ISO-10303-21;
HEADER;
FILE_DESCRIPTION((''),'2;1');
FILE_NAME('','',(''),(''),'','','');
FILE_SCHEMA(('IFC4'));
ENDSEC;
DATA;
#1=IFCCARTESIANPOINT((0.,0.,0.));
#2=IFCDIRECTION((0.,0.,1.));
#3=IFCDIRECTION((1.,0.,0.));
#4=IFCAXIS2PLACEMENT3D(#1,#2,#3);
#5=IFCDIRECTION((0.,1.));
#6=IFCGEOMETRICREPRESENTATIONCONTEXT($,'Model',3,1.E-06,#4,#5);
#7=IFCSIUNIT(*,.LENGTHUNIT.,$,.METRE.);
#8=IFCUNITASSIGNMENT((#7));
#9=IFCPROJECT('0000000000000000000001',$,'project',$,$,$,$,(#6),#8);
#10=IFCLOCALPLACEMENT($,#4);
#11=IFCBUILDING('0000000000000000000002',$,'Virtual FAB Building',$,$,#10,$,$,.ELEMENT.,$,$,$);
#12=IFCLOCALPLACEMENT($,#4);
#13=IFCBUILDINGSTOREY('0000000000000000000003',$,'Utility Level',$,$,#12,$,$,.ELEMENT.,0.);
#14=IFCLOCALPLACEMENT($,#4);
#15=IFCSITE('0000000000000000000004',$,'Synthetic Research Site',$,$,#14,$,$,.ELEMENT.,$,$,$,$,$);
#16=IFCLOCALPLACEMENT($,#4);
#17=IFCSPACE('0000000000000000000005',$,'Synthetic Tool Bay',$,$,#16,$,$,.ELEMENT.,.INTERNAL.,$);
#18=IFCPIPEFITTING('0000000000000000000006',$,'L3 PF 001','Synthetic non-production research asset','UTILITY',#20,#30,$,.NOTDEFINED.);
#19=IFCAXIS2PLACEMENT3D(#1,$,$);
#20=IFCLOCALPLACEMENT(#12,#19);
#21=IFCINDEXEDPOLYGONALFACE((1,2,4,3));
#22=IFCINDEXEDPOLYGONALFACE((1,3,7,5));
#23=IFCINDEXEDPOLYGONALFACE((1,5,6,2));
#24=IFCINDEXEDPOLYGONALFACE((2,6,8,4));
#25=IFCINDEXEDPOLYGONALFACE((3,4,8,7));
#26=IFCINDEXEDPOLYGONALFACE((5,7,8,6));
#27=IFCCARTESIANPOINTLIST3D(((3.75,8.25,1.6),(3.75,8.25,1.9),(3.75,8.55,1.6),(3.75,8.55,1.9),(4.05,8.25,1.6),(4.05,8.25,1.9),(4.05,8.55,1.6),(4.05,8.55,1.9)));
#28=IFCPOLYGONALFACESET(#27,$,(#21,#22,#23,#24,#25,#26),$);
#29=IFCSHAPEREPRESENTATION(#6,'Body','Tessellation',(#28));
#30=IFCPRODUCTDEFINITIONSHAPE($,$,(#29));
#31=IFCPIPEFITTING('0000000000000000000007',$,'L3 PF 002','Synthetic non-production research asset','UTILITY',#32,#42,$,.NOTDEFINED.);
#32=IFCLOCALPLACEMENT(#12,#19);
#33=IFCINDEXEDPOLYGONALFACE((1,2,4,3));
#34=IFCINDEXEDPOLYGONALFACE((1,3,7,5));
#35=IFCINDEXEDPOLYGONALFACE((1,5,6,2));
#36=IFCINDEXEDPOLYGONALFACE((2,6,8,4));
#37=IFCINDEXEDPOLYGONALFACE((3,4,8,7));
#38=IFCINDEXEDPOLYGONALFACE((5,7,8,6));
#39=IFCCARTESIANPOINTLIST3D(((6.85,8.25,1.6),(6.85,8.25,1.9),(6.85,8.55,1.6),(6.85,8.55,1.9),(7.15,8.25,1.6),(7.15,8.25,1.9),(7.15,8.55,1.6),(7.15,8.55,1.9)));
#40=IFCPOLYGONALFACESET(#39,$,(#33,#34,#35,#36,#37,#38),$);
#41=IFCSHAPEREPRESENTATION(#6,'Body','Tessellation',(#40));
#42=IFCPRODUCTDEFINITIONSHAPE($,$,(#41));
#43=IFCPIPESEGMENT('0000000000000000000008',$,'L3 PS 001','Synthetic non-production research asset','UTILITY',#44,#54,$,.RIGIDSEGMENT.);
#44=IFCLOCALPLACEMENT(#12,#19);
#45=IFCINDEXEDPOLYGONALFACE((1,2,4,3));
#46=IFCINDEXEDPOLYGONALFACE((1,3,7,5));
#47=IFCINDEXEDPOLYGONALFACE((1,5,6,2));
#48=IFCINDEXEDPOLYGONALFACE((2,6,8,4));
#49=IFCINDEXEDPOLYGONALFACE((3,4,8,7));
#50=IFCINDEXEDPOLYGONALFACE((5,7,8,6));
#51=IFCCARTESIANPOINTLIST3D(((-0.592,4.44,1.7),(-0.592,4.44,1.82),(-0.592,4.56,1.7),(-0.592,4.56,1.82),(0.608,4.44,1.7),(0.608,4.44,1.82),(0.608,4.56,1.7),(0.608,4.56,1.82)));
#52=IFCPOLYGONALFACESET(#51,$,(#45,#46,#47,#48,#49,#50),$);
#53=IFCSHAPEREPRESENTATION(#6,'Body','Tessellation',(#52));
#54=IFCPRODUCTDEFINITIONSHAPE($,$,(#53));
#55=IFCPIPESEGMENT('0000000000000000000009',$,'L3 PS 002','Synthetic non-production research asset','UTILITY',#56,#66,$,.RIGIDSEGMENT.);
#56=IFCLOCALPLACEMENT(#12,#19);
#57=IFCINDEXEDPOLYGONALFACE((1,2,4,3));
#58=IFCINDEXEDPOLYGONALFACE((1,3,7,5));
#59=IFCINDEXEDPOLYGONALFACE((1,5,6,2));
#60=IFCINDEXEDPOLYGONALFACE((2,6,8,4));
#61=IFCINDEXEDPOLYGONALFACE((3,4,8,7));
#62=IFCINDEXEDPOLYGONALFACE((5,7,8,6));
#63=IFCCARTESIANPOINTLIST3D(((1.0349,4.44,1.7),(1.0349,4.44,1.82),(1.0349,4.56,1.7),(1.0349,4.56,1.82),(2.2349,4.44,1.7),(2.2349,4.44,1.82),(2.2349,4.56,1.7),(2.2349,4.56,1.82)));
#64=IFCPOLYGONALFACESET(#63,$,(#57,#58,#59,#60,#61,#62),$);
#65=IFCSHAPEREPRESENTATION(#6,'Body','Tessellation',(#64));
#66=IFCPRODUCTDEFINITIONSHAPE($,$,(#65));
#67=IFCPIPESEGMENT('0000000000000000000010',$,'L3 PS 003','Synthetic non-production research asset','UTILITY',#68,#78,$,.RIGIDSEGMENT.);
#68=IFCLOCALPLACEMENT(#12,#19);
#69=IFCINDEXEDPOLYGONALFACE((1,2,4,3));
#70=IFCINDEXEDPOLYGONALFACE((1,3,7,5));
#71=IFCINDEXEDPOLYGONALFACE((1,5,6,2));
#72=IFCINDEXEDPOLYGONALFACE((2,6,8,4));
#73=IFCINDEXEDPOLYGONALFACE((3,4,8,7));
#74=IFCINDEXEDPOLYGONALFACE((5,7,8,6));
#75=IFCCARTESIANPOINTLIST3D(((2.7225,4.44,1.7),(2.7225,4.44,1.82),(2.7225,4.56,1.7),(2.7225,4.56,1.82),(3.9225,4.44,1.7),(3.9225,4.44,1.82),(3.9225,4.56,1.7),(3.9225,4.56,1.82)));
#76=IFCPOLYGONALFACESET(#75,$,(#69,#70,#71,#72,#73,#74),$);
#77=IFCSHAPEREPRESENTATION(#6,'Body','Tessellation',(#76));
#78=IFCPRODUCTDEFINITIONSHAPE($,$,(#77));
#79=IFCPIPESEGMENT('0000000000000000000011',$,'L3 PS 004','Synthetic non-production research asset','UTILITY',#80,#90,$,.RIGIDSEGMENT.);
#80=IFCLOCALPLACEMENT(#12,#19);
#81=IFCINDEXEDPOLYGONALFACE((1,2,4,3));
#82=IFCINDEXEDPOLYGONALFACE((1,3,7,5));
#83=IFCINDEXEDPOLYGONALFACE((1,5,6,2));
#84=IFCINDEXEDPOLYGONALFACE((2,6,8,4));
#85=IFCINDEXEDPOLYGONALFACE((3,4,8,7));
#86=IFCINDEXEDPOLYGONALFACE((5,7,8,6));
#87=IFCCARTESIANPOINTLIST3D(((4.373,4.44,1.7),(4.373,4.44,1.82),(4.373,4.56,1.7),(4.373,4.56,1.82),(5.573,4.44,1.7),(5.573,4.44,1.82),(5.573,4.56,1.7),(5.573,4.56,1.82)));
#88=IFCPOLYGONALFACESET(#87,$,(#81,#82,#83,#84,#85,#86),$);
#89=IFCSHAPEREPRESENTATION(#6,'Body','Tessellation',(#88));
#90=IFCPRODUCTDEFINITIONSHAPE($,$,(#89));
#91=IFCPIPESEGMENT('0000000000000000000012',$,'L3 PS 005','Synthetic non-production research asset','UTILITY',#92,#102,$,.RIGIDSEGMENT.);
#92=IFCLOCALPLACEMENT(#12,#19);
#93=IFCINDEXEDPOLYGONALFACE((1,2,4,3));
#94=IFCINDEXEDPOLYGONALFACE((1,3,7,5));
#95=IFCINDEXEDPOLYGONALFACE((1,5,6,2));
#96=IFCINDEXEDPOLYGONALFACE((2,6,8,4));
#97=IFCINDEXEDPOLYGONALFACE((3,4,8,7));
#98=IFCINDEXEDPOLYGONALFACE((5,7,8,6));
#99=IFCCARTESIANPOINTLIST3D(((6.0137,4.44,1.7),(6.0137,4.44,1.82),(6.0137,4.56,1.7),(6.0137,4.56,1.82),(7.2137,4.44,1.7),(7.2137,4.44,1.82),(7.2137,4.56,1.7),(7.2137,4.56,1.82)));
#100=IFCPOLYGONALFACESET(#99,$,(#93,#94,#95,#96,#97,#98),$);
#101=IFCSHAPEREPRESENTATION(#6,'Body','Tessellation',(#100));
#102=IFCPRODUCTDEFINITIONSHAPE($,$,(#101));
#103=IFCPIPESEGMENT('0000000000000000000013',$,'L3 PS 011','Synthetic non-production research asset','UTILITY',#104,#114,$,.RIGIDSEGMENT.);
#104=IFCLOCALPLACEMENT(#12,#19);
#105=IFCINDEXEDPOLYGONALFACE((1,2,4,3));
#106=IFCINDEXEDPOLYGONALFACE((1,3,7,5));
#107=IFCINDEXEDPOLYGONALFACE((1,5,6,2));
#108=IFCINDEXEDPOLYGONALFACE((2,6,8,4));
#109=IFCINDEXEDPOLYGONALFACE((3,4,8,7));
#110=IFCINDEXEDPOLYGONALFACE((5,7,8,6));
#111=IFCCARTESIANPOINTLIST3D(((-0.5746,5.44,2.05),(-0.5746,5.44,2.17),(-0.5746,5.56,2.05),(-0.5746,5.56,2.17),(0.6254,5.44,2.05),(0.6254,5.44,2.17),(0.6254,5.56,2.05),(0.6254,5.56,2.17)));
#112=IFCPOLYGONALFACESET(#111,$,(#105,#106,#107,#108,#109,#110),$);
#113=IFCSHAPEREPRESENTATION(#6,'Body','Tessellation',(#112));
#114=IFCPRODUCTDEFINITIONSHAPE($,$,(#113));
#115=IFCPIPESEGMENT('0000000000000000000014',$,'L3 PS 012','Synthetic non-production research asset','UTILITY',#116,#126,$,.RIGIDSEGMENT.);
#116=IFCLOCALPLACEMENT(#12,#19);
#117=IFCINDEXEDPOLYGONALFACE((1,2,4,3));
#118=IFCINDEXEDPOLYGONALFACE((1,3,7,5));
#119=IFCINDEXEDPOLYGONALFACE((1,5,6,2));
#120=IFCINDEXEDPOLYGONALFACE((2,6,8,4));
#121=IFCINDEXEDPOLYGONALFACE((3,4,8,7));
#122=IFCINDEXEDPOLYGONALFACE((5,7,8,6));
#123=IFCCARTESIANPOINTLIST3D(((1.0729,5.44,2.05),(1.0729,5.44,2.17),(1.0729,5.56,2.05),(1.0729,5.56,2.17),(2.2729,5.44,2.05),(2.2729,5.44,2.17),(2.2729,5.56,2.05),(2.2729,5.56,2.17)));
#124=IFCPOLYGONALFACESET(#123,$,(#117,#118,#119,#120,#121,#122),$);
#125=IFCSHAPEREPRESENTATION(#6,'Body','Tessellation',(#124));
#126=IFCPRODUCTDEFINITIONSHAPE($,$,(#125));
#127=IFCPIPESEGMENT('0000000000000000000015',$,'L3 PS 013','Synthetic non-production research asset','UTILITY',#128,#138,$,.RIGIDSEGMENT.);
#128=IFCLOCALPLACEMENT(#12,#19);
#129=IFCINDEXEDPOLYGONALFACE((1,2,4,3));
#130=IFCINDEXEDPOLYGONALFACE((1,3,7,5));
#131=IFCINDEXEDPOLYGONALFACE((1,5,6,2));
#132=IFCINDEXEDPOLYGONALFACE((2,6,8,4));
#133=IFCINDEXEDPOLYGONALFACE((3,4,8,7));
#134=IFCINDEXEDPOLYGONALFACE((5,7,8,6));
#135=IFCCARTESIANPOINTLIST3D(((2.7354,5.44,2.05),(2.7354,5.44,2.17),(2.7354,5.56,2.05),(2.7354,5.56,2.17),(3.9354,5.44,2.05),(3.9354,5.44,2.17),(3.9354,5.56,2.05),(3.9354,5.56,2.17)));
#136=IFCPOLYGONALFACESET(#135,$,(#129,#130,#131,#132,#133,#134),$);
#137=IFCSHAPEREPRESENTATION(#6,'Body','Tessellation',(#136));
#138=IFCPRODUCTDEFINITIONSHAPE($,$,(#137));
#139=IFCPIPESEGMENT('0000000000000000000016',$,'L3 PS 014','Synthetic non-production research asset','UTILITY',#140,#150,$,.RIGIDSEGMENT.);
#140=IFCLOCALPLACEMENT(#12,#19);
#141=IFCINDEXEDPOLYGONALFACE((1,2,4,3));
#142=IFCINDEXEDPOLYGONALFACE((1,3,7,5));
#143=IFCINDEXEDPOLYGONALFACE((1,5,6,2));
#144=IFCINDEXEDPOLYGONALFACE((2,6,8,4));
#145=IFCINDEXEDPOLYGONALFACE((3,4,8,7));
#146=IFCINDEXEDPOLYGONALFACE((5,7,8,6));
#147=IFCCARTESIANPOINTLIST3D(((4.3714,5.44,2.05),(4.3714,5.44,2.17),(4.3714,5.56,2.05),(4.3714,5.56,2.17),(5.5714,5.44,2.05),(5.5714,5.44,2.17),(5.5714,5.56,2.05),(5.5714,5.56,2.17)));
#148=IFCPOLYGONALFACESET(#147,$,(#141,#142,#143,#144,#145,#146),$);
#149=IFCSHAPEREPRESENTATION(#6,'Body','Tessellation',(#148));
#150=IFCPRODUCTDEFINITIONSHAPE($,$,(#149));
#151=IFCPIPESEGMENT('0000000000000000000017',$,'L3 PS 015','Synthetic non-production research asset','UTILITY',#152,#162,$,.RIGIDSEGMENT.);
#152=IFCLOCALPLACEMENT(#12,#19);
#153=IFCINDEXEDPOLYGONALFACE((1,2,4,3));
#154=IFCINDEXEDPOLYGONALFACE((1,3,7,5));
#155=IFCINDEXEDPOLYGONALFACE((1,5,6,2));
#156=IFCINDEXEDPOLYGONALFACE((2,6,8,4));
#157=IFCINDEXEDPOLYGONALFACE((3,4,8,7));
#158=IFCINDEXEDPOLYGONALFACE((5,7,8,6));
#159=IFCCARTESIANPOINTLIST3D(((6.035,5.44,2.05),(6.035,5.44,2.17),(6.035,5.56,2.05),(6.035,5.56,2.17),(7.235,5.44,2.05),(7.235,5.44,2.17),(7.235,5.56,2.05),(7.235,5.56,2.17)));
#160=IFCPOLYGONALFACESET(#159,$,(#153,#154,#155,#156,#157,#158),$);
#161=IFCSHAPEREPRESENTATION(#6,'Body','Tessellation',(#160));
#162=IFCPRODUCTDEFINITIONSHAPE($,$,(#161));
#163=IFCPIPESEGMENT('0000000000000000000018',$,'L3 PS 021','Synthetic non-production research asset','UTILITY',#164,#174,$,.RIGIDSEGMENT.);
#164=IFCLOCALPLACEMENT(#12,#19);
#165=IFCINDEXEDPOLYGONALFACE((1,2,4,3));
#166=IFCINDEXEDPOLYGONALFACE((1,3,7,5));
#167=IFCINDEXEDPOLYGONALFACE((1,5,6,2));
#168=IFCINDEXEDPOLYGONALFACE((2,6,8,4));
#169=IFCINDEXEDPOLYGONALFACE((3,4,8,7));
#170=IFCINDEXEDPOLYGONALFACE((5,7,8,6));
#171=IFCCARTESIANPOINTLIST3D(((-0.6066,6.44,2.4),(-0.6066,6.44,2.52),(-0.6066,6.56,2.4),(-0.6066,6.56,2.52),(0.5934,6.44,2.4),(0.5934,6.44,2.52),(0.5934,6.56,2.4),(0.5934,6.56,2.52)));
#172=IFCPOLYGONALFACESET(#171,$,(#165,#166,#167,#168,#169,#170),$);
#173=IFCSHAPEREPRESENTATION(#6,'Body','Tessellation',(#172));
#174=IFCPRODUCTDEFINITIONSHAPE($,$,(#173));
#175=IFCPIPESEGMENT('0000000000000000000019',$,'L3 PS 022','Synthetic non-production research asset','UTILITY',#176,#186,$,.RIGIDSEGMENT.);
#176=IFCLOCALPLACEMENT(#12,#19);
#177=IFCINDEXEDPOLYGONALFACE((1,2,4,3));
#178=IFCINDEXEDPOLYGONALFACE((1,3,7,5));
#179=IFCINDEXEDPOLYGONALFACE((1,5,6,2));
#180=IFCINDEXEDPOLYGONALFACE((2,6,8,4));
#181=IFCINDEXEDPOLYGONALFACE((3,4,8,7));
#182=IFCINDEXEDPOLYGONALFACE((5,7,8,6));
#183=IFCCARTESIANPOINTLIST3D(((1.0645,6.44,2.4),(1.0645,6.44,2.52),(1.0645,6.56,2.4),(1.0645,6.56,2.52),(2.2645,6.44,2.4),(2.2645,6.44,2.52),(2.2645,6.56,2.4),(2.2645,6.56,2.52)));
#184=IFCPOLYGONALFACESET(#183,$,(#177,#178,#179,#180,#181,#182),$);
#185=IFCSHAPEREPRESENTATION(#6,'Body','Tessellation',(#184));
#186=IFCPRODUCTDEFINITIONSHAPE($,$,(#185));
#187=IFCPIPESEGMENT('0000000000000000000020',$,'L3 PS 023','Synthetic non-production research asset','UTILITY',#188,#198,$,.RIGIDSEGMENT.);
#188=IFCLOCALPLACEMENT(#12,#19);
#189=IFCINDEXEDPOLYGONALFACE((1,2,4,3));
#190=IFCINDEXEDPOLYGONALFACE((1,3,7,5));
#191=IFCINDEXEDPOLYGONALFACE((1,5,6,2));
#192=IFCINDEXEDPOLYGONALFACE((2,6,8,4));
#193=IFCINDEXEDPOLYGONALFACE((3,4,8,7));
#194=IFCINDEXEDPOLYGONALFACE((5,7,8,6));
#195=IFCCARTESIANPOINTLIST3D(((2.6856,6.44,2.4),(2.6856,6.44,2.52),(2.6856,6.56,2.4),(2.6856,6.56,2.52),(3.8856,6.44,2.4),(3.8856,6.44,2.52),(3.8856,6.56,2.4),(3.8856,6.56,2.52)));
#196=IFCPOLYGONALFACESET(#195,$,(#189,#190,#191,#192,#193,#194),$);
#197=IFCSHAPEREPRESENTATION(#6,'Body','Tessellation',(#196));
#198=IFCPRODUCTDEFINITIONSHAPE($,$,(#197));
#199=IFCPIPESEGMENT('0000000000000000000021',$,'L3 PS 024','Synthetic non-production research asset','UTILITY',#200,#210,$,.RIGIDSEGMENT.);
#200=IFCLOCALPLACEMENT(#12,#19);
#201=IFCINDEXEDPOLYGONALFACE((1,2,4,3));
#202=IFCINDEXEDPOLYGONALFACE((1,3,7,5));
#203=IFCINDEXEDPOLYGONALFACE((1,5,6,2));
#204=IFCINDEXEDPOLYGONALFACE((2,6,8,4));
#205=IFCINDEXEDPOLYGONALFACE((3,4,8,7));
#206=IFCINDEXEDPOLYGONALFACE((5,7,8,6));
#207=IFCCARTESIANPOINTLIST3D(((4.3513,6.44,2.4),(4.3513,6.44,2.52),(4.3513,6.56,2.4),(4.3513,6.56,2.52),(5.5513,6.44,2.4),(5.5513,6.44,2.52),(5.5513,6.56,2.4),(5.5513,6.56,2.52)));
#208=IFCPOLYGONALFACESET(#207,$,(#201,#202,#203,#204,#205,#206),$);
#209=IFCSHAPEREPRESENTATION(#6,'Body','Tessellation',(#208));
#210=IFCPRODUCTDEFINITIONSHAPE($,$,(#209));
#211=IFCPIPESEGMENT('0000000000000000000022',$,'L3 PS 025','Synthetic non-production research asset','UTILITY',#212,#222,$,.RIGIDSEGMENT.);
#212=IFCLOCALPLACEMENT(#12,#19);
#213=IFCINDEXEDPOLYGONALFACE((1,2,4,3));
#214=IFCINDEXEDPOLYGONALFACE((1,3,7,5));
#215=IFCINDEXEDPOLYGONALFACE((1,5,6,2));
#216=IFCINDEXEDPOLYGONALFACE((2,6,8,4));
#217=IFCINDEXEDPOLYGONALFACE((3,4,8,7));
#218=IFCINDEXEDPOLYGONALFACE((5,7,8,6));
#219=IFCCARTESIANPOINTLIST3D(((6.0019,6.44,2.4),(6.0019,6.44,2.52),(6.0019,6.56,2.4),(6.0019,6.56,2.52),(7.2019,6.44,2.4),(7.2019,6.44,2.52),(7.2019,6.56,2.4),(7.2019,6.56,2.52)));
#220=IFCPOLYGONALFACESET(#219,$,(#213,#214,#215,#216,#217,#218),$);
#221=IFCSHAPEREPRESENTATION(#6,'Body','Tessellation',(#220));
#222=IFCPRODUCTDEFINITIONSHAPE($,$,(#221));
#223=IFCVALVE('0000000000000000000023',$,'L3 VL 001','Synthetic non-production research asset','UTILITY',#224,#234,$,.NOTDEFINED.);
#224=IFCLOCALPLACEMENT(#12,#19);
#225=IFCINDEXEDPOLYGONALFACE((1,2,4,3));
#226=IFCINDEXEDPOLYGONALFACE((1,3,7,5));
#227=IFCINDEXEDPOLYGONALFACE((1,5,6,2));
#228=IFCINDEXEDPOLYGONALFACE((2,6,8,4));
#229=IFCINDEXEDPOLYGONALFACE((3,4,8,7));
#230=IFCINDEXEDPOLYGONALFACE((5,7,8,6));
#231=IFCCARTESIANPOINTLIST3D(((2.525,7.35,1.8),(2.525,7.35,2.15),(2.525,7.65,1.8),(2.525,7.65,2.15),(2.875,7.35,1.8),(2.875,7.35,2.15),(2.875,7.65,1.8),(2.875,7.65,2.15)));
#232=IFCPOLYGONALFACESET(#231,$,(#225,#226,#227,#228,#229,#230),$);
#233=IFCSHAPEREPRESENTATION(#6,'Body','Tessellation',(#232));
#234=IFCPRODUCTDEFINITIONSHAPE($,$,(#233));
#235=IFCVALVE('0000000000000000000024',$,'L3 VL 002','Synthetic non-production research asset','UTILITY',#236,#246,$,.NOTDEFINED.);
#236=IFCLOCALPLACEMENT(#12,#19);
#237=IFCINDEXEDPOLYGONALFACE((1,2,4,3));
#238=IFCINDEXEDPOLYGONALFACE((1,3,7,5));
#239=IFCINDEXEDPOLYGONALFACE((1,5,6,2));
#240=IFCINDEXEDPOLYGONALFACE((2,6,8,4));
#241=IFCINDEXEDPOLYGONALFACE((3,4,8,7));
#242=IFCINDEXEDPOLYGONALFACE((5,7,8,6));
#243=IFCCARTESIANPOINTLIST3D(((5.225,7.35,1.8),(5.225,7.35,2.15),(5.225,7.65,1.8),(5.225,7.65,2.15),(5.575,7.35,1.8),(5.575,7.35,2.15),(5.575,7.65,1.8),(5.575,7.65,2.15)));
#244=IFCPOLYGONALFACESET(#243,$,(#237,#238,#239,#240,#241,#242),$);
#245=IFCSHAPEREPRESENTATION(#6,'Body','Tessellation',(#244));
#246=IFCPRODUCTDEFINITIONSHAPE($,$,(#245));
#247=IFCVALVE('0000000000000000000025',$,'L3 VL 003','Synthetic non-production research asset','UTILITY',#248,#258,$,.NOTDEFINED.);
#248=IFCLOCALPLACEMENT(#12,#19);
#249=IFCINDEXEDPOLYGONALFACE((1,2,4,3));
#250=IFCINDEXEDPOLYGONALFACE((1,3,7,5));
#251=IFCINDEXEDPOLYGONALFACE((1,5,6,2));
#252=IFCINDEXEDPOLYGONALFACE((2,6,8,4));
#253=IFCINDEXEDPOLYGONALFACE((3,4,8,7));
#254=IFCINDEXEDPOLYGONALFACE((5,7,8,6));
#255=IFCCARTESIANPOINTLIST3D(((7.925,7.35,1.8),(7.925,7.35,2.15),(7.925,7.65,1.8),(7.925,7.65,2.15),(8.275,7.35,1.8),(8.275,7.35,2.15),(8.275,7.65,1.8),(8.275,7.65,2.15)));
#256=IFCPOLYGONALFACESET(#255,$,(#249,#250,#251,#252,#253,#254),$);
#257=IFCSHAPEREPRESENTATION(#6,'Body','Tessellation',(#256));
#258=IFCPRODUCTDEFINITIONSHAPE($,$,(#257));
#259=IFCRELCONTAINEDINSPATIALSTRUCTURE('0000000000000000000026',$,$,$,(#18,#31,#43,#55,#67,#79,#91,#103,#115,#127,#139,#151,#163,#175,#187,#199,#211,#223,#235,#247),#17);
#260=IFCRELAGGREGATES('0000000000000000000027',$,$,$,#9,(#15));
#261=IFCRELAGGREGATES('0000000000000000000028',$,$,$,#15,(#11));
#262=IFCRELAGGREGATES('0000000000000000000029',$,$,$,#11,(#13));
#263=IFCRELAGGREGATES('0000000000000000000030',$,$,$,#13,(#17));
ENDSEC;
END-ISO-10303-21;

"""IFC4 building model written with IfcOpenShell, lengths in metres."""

from ifc_helpers import new_model, si_unit, direction, frame, origin_with_axes, origin_2d_with_axis, place, context, project, spatial, rectangle, extrude, element, save


model = new_model("IFC4")

# Units and contexts
model_context = context("Model", 3, precision=1e-06, world=origin_with_axes(), true_north=direction((0.0, 1.0)))
ifc_project = project(units=[si_unit("LENGTHUNIT", "METRE")], contexts=[model_context])

# Site, building, storey, space
site_placement = place(None, origin_with_axes())
site = spatial("IfcSite", under=ifc_project, at=site_placement, Name="Synthetic Research Site", CompositionType="ELEMENT")
building_placement = place(None, origin_with_axes())
building = spatial("IfcBuilding", under=site, at=building_placement, Name="Virtual FAB Building", CompositionType="ELEMENT")
storey_placement = place(None, origin_with_axes())
storey = spatial("IfcBuildingStorey", under=building, at=storey_placement, Name="Utility Level", CompositionType="ELEMENT", Elevation=0.0)
space_placement = place(None, origin_with_axes())
space = spatial("IfcSpace", under=storey, at=space_placement, Name="Synthetic Tool Bay", CompositionType="ELEMENT", PredefinedType="INTERNAL")

# Pipe fittings
for number, where, z_axis, x_axis, name in (
    (1, (3.9, 8.4, 1.6), (0.0, 0.0, 1.0), (1.0, 0.0, 0.0), "L3 PF 001"),
    (2, (7.0, 8.4, 1.6), (0.0, 0.0, 1.0), (1.0, 0.0, 0.0), "L3 PF 002"),
):
    element("IfcPipeFitting", number, at=place(None, frame(where, z_axis=z_axis, x_axis=x_axis)), inside=space, Name=name, Description="Synthetic non-production research asset", ObjectType="UTILITY", PredefinedType="NOTDEFINED", context=model_context, shape_type="SweptSolid", body=[
        extrude(rectangle(XDim=0.3, YDim=0.3, at=origin_2d_with_axis()), origin_with_axes(), (0.0, 0.0, 1.0), 0.3),
    ])

# Pipe segments
for number, where, z_axis, x_axis, name in (
    (3, (0.008, 4.5, 1.7), (0.0, 0.0, 1.0), (1.0, 0.0, 0.0), "L3 PS 001"),
    (4, (1.6349, 4.5, 1.7), (0.0, 0.0, 1.0), (1.0, 0.0, 0.0), "L3 PS 002"),
    (5, (3.3225, 4.5, 1.7), (0.0, 0.0, 1.0), (1.0, 0.0, 0.0), "L3 PS 003"),
    (6, (4.973, 4.5, 1.7), (0.0, 0.0, 1.0), (1.0, 0.0, 0.0), "L3 PS 004"),
    (7, (6.6137, 4.5, 1.7), (0.0, 0.0, 1.0), (1.0, 0.0, 0.0), "L3 PS 005"),
    (8, (0.0254, 5.5, 2.05), (0.0, 0.0, 1.0), (1.0, 0.0, 0.0), "L3 PS 011"),
    (9, (1.6729, 5.5, 2.05), (0.0, 0.0, 1.0), (1.0, 0.0, 0.0), "L3 PS 012"),
    (10, (3.3354, 5.5, 2.05), (0.0, 0.0, 1.0), (1.0, 0.0, 0.0), "L3 PS 013"),
    (11, (4.9714, 5.5, 2.05), (0.0, 0.0, 1.0), (1.0, 0.0, 0.0), "L3 PS 014"),
    (12, (6.635, 5.5, 2.05), (0.0, 0.0, 1.0), (1.0, 0.0, 0.0), "L3 PS 015"),
    (13, (-0.0066, 6.5, 2.4), (0.0, 0.0, 1.0), (1.0, 0.0, 0.0), "L3 PS 021"),
    (14, (1.6645, 6.5, 2.4), (0.0, 0.0, 1.0), (1.0, 0.0, 0.0), "L3 PS 022"),
    (15, (3.2856, 6.5, 2.4), (0.0, 0.0, 1.0), (1.0, 0.0, 0.0), "L3 PS 023"),
    (16, (4.9513, 6.5, 2.4), (0.0, 0.0, 1.0), (1.0, 0.0, 0.0), "L3 PS 024"),
    (17, (6.6019, 6.5, 2.4), (0.0, 0.0, 1.0), (1.0, 0.0, 0.0), "L3 PS 025"),
):
    element("IfcPipeSegment", number, at=place(None, frame(where, z_axis=z_axis, x_axis=x_axis)), inside=space, Name=name, Description="Synthetic non-production research asset", ObjectType="UTILITY", PredefinedType="RIGIDSEGMENT", context=model_context, shape_type="SweptSolid", body=[
        extrude(rectangle(XDim=1.2, YDim=0.12, at=origin_2d_with_axis()), origin_with_axes(), (0.0, 0.0, 1.0), 0.12),
    ])

# Valves
for number, where, z_axis, x_axis, name in (
    (18, (2.7, 7.5, 1.8), (0.0, 0.0, 1.0), (1.0, 0.0, 0.0), "L3 VL 001"),
    (19, (5.4, 7.5, 1.8), (0.0, 0.0, 1.0), (1.0, 0.0, 0.0), "L3 VL 002"),
    (20, (8.1, 7.5, 1.8), (0.0, 0.0, 1.0), (1.0, 0.0, 0.0), "L3 VL 003"),
):
    element("IfcValve", number, at=place(None, frame(where, z_axis=z_axis, x_axis=x_axis)), inside=space, Name=name, Description="Synthetic non-production research asset", ObjectType="UTILITY", PredefinedType="NOTDEFINED", context=model_context, shape_type="SweptSolid", body=[
        extrude(rectangle(XDim=0.35, YDim=0.3, at=origin_2d_with_axis()), origin_with_axes(), (0.0, 0.0, 1.0), 0.35),
    ])

save(model, "model.ifc")
